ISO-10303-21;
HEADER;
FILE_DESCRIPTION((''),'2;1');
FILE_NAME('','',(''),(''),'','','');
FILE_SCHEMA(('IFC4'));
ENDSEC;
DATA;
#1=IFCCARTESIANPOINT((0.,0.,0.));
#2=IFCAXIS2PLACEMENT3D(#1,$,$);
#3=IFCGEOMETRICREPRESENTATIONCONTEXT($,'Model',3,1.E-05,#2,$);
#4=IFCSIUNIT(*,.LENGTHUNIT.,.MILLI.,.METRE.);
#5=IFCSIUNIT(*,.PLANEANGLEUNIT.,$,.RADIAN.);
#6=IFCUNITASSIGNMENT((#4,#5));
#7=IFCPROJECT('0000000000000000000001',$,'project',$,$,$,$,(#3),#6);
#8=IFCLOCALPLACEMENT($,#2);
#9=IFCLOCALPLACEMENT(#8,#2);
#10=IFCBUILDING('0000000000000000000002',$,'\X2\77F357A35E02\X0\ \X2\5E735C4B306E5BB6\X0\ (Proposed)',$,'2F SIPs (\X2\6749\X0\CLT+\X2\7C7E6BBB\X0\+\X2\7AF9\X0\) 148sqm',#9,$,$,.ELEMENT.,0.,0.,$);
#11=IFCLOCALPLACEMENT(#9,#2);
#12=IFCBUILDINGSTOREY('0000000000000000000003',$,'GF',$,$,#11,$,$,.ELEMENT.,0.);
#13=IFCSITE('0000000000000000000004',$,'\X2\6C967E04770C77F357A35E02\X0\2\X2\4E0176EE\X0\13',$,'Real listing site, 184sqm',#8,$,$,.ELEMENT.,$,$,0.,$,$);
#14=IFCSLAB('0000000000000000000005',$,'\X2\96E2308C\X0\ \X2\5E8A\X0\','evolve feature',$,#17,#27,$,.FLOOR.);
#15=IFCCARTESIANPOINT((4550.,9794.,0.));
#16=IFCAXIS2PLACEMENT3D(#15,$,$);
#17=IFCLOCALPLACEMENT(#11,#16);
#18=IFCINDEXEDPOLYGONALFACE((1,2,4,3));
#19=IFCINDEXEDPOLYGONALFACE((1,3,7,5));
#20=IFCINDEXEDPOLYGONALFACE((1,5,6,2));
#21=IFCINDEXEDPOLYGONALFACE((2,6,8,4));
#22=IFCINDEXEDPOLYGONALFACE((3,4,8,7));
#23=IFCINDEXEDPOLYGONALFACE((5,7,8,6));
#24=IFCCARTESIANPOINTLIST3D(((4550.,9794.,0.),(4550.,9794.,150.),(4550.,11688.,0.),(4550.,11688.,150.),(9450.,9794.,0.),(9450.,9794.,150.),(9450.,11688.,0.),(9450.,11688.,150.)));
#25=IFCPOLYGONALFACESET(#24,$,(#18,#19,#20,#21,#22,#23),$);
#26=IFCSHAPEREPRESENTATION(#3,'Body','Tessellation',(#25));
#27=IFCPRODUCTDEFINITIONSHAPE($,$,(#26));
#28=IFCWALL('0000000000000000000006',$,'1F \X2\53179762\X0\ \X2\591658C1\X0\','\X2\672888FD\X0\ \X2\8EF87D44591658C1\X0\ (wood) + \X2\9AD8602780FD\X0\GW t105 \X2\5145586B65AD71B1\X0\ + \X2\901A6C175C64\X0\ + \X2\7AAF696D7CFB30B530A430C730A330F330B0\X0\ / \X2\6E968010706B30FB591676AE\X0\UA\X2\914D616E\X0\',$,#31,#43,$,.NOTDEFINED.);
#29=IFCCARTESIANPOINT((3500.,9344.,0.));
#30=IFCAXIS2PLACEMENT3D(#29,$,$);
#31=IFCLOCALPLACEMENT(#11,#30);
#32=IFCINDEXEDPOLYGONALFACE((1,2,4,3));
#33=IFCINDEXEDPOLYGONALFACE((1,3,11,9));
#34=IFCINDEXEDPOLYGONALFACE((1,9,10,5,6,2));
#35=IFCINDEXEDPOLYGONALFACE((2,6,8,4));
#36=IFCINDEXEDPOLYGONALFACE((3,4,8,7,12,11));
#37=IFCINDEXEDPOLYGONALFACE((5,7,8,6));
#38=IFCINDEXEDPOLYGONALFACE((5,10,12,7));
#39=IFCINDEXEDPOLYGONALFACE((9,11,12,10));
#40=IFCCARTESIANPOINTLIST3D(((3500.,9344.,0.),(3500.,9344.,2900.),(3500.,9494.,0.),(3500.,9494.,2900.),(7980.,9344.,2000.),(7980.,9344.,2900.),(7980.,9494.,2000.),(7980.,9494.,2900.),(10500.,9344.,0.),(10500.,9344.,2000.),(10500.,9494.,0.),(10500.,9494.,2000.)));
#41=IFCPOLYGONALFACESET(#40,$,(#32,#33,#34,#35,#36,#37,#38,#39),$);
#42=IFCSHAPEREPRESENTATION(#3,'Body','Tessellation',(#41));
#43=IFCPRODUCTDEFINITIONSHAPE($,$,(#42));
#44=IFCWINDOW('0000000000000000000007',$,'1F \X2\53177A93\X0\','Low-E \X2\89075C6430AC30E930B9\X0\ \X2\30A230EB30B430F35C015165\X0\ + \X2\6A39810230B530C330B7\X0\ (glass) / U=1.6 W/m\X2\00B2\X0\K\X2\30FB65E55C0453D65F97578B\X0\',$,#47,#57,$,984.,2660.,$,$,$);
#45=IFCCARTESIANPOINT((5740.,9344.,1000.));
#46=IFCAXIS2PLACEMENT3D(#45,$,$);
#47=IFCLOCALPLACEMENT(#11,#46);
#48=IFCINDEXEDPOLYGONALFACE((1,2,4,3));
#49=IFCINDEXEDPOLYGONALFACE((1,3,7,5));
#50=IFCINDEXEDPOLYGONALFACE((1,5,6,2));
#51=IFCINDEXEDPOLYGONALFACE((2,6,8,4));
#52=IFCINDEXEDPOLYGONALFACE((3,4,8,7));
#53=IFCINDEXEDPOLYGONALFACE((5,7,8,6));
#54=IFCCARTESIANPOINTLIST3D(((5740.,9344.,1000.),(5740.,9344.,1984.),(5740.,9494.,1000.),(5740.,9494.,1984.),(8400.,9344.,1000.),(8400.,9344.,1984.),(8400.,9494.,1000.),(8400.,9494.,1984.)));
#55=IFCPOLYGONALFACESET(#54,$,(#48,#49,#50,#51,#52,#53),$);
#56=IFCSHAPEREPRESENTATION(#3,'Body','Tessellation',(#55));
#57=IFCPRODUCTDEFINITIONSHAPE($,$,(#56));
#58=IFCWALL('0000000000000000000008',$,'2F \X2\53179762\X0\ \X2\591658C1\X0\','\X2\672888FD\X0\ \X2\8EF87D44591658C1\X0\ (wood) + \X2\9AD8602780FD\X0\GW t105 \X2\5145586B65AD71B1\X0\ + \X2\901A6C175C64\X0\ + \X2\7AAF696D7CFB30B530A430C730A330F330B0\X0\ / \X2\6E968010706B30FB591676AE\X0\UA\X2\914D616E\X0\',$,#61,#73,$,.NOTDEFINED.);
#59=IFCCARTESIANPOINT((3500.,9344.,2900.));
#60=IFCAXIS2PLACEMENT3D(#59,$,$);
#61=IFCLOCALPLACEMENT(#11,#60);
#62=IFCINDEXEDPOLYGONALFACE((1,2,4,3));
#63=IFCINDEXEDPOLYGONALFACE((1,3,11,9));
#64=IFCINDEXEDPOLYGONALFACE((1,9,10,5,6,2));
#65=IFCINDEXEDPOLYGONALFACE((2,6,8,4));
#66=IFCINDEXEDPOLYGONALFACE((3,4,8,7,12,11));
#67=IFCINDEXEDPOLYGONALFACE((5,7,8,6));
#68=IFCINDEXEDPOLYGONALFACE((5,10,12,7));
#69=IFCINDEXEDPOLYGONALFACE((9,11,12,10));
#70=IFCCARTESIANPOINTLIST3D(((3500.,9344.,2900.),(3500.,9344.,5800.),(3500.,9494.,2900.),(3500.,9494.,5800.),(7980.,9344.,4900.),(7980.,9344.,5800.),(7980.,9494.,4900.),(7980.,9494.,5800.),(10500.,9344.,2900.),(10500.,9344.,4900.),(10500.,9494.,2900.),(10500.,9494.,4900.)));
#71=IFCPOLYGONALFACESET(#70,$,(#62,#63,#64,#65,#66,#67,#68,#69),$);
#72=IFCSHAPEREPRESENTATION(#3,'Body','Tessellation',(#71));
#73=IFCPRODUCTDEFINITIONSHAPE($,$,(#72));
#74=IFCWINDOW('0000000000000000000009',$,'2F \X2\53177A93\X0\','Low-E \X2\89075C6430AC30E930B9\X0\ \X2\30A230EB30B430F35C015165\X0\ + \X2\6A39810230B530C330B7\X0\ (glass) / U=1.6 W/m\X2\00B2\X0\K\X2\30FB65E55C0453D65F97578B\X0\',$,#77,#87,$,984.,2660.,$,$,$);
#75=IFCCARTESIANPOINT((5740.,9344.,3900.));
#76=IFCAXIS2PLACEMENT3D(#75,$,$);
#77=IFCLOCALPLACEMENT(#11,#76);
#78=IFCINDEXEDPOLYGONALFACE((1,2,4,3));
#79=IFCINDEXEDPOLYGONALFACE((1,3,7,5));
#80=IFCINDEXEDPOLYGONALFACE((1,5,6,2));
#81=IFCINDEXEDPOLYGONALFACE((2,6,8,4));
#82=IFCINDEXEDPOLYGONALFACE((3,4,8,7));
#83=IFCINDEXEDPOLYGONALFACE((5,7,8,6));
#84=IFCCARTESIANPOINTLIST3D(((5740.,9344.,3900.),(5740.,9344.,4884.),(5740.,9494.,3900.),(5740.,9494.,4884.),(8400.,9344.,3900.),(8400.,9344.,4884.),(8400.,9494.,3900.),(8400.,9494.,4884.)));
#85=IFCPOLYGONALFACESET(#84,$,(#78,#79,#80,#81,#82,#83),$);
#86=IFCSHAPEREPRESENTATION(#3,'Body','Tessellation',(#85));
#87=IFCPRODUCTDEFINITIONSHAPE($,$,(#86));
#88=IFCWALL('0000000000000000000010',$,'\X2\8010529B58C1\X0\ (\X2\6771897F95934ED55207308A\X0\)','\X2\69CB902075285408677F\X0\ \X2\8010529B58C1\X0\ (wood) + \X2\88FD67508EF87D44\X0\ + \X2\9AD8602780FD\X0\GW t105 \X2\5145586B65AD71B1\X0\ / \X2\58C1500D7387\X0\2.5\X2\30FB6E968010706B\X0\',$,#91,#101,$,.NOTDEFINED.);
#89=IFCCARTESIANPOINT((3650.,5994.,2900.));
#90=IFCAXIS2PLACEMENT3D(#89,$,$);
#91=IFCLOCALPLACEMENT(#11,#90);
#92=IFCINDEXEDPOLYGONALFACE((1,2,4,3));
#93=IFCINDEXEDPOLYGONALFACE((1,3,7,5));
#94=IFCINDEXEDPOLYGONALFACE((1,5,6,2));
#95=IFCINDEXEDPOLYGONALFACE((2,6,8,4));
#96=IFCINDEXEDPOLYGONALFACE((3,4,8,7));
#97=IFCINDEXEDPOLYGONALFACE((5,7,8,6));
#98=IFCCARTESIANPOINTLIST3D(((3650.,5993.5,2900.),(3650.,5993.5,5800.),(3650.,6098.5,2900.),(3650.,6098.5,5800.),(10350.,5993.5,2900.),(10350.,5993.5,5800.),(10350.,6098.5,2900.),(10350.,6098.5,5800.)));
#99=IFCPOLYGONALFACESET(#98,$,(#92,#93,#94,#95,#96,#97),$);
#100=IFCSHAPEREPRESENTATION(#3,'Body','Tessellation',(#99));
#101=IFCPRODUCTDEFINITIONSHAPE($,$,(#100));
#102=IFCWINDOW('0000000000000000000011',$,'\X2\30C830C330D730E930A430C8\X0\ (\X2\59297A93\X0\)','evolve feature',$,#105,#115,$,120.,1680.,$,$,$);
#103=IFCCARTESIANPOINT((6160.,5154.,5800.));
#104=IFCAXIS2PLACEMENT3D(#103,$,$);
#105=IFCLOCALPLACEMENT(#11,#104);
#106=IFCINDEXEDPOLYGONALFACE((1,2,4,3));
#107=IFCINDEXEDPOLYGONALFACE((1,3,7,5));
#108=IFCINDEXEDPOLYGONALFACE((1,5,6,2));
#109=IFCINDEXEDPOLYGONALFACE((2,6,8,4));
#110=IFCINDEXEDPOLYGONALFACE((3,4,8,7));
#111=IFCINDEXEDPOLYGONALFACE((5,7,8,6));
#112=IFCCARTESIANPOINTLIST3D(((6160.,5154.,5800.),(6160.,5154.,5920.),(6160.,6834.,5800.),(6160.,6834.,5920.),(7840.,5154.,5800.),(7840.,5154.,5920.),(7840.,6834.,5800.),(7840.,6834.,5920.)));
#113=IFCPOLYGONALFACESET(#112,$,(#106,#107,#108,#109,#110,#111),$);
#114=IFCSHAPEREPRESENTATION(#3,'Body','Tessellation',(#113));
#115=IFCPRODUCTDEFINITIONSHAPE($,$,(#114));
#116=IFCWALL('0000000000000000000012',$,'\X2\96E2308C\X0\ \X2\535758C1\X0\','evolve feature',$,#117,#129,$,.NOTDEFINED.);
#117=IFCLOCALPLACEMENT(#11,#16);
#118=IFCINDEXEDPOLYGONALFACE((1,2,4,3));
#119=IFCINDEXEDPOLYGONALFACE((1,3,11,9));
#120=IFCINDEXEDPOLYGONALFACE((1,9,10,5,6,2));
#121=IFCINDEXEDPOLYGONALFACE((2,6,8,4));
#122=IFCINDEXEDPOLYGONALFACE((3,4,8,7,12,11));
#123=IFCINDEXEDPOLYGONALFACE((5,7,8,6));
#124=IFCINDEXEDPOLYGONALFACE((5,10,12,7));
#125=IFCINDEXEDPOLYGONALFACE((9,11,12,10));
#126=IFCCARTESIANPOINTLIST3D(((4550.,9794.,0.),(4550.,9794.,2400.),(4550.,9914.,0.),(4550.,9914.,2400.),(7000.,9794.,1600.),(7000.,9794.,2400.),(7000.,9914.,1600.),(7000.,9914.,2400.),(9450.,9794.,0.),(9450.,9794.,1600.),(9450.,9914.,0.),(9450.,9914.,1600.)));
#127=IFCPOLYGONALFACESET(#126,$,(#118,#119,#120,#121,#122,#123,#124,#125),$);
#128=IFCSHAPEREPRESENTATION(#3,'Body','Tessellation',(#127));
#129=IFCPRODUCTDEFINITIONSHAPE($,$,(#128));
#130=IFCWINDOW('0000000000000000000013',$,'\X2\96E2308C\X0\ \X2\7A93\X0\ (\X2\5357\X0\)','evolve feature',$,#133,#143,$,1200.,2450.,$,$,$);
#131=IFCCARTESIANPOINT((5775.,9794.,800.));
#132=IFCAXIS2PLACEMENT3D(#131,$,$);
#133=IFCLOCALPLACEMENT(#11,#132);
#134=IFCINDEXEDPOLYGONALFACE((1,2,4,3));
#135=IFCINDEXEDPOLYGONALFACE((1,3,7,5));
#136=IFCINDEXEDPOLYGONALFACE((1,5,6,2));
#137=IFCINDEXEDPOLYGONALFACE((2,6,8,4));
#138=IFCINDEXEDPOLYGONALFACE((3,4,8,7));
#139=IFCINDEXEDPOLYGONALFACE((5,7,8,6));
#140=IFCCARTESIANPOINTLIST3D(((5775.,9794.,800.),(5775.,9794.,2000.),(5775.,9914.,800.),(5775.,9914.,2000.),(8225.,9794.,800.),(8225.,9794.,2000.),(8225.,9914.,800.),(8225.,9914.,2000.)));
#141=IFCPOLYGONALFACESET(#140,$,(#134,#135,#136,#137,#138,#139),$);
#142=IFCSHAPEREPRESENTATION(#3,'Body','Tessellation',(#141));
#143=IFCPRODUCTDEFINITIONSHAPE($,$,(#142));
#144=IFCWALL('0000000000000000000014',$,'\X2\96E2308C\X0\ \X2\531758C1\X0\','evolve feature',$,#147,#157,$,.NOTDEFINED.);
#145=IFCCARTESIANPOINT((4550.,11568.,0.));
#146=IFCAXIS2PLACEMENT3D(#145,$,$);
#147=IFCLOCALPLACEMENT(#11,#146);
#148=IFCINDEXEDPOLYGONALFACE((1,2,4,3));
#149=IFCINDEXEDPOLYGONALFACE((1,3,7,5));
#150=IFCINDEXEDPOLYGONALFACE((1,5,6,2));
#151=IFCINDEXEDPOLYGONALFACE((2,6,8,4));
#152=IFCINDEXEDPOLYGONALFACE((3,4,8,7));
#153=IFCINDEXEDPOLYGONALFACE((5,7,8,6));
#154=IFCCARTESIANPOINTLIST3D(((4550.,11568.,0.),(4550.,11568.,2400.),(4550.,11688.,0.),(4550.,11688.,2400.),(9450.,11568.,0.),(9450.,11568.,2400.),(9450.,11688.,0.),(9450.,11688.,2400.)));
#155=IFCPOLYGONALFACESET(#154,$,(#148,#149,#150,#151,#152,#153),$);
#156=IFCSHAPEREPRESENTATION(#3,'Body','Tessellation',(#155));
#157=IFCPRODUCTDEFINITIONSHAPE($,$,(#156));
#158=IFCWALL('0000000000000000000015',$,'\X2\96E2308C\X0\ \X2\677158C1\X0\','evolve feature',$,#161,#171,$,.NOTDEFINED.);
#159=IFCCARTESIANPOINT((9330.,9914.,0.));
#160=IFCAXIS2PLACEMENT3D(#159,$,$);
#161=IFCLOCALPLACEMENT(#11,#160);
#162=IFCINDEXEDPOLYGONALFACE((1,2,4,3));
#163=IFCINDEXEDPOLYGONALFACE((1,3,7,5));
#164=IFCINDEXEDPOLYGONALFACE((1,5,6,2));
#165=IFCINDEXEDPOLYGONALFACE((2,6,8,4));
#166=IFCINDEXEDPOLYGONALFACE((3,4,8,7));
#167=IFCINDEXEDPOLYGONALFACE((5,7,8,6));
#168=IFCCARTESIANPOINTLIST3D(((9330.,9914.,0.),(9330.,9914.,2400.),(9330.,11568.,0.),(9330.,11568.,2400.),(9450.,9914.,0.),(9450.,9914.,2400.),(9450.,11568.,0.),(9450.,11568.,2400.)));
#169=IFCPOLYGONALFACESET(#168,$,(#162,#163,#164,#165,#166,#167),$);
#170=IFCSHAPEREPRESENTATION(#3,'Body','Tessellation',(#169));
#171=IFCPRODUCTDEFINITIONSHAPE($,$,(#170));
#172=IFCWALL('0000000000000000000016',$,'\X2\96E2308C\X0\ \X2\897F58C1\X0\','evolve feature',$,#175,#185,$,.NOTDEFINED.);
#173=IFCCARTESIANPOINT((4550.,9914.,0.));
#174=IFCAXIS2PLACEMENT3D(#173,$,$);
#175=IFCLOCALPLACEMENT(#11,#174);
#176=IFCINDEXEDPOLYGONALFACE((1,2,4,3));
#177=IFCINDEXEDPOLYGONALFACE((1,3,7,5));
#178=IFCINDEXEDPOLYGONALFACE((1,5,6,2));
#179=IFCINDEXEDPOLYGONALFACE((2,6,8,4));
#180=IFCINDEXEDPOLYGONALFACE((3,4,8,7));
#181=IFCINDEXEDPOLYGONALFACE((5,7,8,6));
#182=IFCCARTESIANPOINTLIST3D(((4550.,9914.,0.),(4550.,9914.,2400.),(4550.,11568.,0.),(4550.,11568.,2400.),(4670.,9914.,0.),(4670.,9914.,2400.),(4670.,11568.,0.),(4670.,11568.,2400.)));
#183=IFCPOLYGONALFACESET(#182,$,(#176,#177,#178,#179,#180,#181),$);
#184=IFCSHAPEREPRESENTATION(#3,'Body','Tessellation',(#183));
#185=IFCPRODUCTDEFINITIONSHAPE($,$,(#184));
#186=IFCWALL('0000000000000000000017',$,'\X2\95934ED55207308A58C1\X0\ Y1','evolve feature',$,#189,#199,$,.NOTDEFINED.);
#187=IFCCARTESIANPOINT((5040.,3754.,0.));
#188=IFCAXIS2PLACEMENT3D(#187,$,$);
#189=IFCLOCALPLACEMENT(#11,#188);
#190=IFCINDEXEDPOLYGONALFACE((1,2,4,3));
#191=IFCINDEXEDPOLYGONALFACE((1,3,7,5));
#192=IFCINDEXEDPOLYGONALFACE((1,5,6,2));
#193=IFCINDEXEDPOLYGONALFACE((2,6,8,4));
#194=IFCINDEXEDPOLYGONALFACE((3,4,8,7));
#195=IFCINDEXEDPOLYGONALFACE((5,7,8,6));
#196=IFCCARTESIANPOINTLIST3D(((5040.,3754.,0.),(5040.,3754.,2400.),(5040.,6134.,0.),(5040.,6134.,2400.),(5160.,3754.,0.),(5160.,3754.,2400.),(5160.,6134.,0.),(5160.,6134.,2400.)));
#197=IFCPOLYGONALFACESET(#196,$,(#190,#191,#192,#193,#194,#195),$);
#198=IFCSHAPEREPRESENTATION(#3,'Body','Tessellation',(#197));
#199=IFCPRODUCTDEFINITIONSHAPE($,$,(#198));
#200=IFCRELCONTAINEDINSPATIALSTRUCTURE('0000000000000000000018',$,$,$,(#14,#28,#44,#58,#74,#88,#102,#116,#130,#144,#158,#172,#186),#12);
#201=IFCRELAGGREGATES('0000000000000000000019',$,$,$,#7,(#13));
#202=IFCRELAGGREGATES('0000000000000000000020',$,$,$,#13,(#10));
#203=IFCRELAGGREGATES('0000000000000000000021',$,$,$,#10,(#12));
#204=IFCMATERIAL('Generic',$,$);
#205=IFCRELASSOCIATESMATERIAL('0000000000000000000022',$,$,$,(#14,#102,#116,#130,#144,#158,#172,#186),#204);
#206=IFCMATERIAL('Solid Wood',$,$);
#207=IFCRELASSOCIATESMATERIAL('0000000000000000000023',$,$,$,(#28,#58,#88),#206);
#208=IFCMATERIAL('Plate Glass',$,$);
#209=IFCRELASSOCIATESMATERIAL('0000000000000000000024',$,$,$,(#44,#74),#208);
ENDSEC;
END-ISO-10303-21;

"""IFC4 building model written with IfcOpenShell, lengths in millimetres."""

from ifc_helpers import new_model, si_unit, frame, frame_2d, origin, place, context, project, spatial, rectangle, extrude, material, element, fill, save


model = new_model("IFC4")

# Units and contexts
model_context = context("Model", 3, precision=1e-05, world=origin())
ifc_project = project(units=[si_unit("LENGTHUNIT", "METRE", prefix="MILLI"), si_unit("PLANEANGLEUNIT", "RADIAN")], contexts=[model_context])

# Site, building, storey
site_placement = place(None, origin())
site = spatial("IfcSite", under=ifc_project, at=site_placement, Name="沖縄県石垣市2丁目13", ObjectType="Real listing site, 184sqm", CompositionType="ELEMENT", RefElevation=0.0)
building_placement = place(site_placement, origin())
building = spatial("IfcBuilding", under=site, at=building_placement, Name="石垣市 平屋の家 (Proposed)", ObjectType="2F SIPs (杉CLT+籾殻+竹) 148sqm", CompositionType="ELEMENT", ElevationOfRefHeight=0.0, ElevationOfTerrain=0.0)
storey_placement = place(building_placement, origin())
storey = spatial("IfcBuildingStorey", under=building, at=storey_placement, Name="GF", CompositionType="ELEMENT", Elevation=0.0)

# Slab
ifc_material_1 = material(Name="Generic")
slab_placement = place(storey_placement, frame((4550.0, 9794.0, 0.0)))
element("IfcSlab", 1, at=slab_placement, inside=storey, material=ifc_material_1, Name="離れ 床", Description="evolve feature", PredefinedType="FLOOR", context=model_context, shape_type="SweptSolid", body=[
    extrude(rectangle(XDim=4900.0, YDim=1894.0, at=frame_2d((2450.0, 947.0))), frame((4550.0, 9794.0, 0.0)), (0.0, 0.0, 1.0), 150.0),
])

# Wall, opening, window
ifc_material_2 = material(Name="Solid Wood")
wall_1_placement = place(storey_placement, frame((3500.0, 9344.0, 0.0)))
wall_1 = element("IfcWall", 2, at=wall_1_placement, inside=storey, material=ifc_material_2, Name="1F 北面 外壁", Description="木製 軸組外壁 (wood) + 高性能GW t105 充填断熱 + 通気層 + 窯業系サイディング / 準耐火・外皮UA配慮", PredefinedType="NOTDEFINED", context=model_context, shape_type="SweptSolid", body=[
    extrude(rectangle(XDim=7000.0, YDim=150.0, at=frame_2d((3500.0, 75.0))), frame((3500.0, 9344.0, 0.0)), (0.0, 0.0, 1.0), 2900.0),
])
opening_1_placement = place(storey_placement, frame((5740.0, 9344.0, 1000.0)))
opening_1 = element("IfcOpeningElement", 3, at=opening_1_placement, cuts=wall_1, PredefinedType="NOTDEFINED", context=model_context, shape_type="SweptSolid", body=[
    extrude(rectangle(XDim=2660.0, YDim=150.0, at=frame_2d((1330.0, 75.0))), frame((5740.0, 9344.0, 1000.0)), (0.0, 0.0, 1.0), 984.0),
])
ifc_material_3 = material(Name="Plate Glass")
window_1_placement = place(storey_placement, frame((5740.0, 9344.0, 1000.0)))
window_1 = element("IfcWindow", 4, at=window_1_placement, inside=storey, material=ifc_material_3, Name="1F 北窓", Description="Low-E 複層ガラス アルゴン封入 + 樹脂サッシ (glass) / U=1.6 W/m²K・日射取得型", OverallHeight=984.0, OverallWidth=2660.0, context=model_context, shape_type="SweptSolid", body=[
    extrude(rectangle(XDim=2660.0, YDim=150.0, at=frame_2d((1330.0, 75.0))), frame((5740.0, 9344.0, 1000.0)), (0.0, 0.0, 1.0), 984.0),
])
fill(opening_1, window_1)

# Wall, opening, window
wall_2_placement = place(storey_placement, frame((3500.0, 9344.0, 2900.0)))
wall_2 = element("IfcWall", 5, at=wall_2_placement, inside=storey, material=ifc_material_2, Name="2F 北面 外壁", Description="木製 軸組外壁 (wood) + 高性能GW t105 充填断熱 + 通気層 + 窯業系サイディング / 準耐火・外皮UA配慮", PredefinedType="NOTDEFINED", context=model_context, shape_type="SweptSolid", body=[
    extrude(rectangle(XDim=7000.0, YDim=150.0, at=frame_2d((3500.0, 75.0))), frame((3500.0, 9344.0, 2900.0)), (0.0, 0.0, 1.0), 2900.0),
])
opening_2_placement = place(storey_placement, frame((5740.0, 9344.0, 3900.0)))
opening_2 = element("IfcOpeningElement", 6, at=opening_2_placement, cuts=wall_2, PredefinedType="NOTDEFINED", context=model_context, shape_type="SweptSolid", body=[
    extrude(rectangle(XDim=2660.0, YDim=150.0, at=frame_2d((1330.0, 75.0))), frame((5740.0, 9344.0, 3900.0)), (0.0, 0.0, 1.0), 984.0),
])
window_2_placement = place(storey_placement, frame((5740.0, 9344.0, 3900.0)))
window_2 = element("IfcWindow", 7, at=window_2_placement, inside=storey, material=ifc_material_3, Name="2F 北窓", Description="Low-E 複層ガラス アルゴン封入 + 樹脂サッシ (glass) / U=1.6 W/m²K・日射取得型", OverallHeight=984.0, OverallWidth=2660.0, context=model_context, shape_type="SweptSolid", body=[
    extrude(rectangle(XDim=2660.0, YDim=150.0, at=frame_2d((1330.0, 75.0))), frame((5740.0, 9344.0, 3900.0)), (0.0, 0.0, 1.0), 984.0),
])
fill(opening_2, window_2)

# Wall
wall_3_placement = place(storey_placement, frame((3650.0, 5994.0, 2900.0)))
element("IfcWall", 8, at=wall_3_placement, inside=storey, material=ifc_material_2, Name="耐力壁 (東西間仕切り)", Description="構造用合板 耐力壁 (wood) + 製材軸組 + 高性能GW t105 充填断熱 / 壁倍率2.5・準耐火", PredefinedType="NOTDEFINED", context=model_context, shape_type="SweptSolid", body=[
    extrude(rectangle(XDim=6700.0, YDim=105.0, at=frame_2d((3350.0, 52.0))), frame((3650.0, 5994.0, 2900.0)), (0.0, 0.0, 1.0), 2900.0),
])

# Window
window_3_placement = place(storey_placement, frame((6160.0, 5154.0, 5800.0)))
element("IfcWindow", 9, at=window_3_placement, inside=storey, material=ifc_material_1, Name="トップライト (天窓)", Description="evolve feature", OverallHeight=120.0, OverallWidth=1680.0, context=model_context, shape_type="SweptSolid", body=[
    extrude(rectangle(XDim=1680.0, YDim=1680.0, at=frame_2d((840.0, 840.0))), frame((6160.0, 5154.0, 5800.0)), (0.0, 0.0, 1.0), 120.0),
])

# Wall, opening, window
wall_4_placement = place(storey_placement, frame((4550.0, 9794.0, 0.0)))
wall_4 = element("IfcWall", 10, at=wall_4_placement, inside=storey, material=ifc_material_1, Name="離れ 南壁", Description="evolve feature", PredefinedType="NOTDEFINED", context=model_context, shape_type="SweptSolid", body=[
    extrude(rectangle(XDim=4900.0, YDim=120.0, at=frame_2d((2450.0, 60.0))), frame((4550.0, 9794.0, 0.0)), (0.0, 0.0, 1.0), 2400.0),
])
opening_3_placement = place(storey_placement, frame((5775.0, 9794.0, 800.0)))
opening_3 = element("IfcOpeningElement", 11, at=opening_3_placement, cuts=wall_4, PredefinedType="NOTDEFINED", context=model_context, shape_type="SweptSolid", body=[
    extrude(rectangle(XDim=2450.0, YDim=120.0, at=frame_2d((1225.0, 60.0))), frame((5775.0, 9794.0, 800.0)), (0.0, 0.0, 1.0), 1200.0),
])
window_4_placement = place(storey_placement, frame((5775.0, 9794.0, 800.0)))
window_4 = element("IfcWindow", 12, at=window_4_placement, inside=storey, material=ifc_material_1, Name="離れ 窓 (南)", Description="evolve feature", OverallHeight=1200.0, OverallWidth=2450.0, context=model_context, shape_type="SweptSolid", body=[
    extrude(rectangle(XDim=2450.0, YDim=120.0, at=frame_2d((1225.0, 60.0))), frame((5775.0, 9794.0, 800.0)), (0.0, 0.0, 1.0), 1200.0),
])
fill(opening_3, window_4)

# Walls
wall_5_placement = place(storey_placement, frame((4550.0, 11568.0, 0.0)))
element("IfcWall", 13, at=wall_5_placement, inside=storey, material=ifc_material_1, Name="離れ 北壁", Description="evolve feature", PredefinedType="NOTDEFINED", context=model_context, shape_type="SweptSolid", body=[
    extrude(rectangle(XDim=4900.0, YDim=120.0, at=frame_2d((2450.0, 60.0))), frame((4550.0, 11568.0, 0.0)), (0.0, 0.0, 1.0), 2400.0),
])
wall_6_placement = place(storey_placement, frame((9330.0, 9914.0, 0.0)))
element("IfcWall", 14, at=wall_6_placement, inside=storey, material=ifc_material_1, Name="離れ 東壁", Description="evolve feature", PredefinedType="NOTDEFINED", context=model_context, shape_type="SweptSolid", body=[
    extrude(rectangle(XDim=120.0, YDim=1654.0, at=frame_2d((60.0, 827.0))), frame((9330.0, 9914.0, 0.0)), (0.0, 0.0, 1.0), 2400.0),
])
wall_7_placement = place(storey_placement, frame((4550.0, 9914.0, 0.0)))
element("IfcWall", 15, at=wall_7_placement, inside=storey, material=ifc_material_1, Name="離れ 西壁", Description="evolve feature", PredefinedType="NOTDEFINED", context=model_context, shape_type="SweptSolid", body=[
    extrude(rectangle(XDim=120.0, YDim=1654.0, at=frame_2d((60.0, 827.0))), frame((4550.0, 9914.0, 0.0)), (0.0, 0.0, 1.0), 2400.0),
])
wall_8_placement = place(storey_placement, frame((5040.0, 3754.0, 0.0)))
element("IfcWall", 16, at=wall_8_placement, inside=storey, material=ifc_material_1, Name="間仕切り壁 Y1", Description="evolve feature", PredefinedType="NOTDEFINED", context=model_context, shape_type="SweptSolid", body=[
    extrude(rectangle(XDim=120.0, YDim=2380.0, at=frame_2d((60.0, 1190.0))), frame((5040.0, 3754.0, 0.0)), (0.0, 0.0, 1.0), 2400.0),
])

save(model, "model.ifc")
